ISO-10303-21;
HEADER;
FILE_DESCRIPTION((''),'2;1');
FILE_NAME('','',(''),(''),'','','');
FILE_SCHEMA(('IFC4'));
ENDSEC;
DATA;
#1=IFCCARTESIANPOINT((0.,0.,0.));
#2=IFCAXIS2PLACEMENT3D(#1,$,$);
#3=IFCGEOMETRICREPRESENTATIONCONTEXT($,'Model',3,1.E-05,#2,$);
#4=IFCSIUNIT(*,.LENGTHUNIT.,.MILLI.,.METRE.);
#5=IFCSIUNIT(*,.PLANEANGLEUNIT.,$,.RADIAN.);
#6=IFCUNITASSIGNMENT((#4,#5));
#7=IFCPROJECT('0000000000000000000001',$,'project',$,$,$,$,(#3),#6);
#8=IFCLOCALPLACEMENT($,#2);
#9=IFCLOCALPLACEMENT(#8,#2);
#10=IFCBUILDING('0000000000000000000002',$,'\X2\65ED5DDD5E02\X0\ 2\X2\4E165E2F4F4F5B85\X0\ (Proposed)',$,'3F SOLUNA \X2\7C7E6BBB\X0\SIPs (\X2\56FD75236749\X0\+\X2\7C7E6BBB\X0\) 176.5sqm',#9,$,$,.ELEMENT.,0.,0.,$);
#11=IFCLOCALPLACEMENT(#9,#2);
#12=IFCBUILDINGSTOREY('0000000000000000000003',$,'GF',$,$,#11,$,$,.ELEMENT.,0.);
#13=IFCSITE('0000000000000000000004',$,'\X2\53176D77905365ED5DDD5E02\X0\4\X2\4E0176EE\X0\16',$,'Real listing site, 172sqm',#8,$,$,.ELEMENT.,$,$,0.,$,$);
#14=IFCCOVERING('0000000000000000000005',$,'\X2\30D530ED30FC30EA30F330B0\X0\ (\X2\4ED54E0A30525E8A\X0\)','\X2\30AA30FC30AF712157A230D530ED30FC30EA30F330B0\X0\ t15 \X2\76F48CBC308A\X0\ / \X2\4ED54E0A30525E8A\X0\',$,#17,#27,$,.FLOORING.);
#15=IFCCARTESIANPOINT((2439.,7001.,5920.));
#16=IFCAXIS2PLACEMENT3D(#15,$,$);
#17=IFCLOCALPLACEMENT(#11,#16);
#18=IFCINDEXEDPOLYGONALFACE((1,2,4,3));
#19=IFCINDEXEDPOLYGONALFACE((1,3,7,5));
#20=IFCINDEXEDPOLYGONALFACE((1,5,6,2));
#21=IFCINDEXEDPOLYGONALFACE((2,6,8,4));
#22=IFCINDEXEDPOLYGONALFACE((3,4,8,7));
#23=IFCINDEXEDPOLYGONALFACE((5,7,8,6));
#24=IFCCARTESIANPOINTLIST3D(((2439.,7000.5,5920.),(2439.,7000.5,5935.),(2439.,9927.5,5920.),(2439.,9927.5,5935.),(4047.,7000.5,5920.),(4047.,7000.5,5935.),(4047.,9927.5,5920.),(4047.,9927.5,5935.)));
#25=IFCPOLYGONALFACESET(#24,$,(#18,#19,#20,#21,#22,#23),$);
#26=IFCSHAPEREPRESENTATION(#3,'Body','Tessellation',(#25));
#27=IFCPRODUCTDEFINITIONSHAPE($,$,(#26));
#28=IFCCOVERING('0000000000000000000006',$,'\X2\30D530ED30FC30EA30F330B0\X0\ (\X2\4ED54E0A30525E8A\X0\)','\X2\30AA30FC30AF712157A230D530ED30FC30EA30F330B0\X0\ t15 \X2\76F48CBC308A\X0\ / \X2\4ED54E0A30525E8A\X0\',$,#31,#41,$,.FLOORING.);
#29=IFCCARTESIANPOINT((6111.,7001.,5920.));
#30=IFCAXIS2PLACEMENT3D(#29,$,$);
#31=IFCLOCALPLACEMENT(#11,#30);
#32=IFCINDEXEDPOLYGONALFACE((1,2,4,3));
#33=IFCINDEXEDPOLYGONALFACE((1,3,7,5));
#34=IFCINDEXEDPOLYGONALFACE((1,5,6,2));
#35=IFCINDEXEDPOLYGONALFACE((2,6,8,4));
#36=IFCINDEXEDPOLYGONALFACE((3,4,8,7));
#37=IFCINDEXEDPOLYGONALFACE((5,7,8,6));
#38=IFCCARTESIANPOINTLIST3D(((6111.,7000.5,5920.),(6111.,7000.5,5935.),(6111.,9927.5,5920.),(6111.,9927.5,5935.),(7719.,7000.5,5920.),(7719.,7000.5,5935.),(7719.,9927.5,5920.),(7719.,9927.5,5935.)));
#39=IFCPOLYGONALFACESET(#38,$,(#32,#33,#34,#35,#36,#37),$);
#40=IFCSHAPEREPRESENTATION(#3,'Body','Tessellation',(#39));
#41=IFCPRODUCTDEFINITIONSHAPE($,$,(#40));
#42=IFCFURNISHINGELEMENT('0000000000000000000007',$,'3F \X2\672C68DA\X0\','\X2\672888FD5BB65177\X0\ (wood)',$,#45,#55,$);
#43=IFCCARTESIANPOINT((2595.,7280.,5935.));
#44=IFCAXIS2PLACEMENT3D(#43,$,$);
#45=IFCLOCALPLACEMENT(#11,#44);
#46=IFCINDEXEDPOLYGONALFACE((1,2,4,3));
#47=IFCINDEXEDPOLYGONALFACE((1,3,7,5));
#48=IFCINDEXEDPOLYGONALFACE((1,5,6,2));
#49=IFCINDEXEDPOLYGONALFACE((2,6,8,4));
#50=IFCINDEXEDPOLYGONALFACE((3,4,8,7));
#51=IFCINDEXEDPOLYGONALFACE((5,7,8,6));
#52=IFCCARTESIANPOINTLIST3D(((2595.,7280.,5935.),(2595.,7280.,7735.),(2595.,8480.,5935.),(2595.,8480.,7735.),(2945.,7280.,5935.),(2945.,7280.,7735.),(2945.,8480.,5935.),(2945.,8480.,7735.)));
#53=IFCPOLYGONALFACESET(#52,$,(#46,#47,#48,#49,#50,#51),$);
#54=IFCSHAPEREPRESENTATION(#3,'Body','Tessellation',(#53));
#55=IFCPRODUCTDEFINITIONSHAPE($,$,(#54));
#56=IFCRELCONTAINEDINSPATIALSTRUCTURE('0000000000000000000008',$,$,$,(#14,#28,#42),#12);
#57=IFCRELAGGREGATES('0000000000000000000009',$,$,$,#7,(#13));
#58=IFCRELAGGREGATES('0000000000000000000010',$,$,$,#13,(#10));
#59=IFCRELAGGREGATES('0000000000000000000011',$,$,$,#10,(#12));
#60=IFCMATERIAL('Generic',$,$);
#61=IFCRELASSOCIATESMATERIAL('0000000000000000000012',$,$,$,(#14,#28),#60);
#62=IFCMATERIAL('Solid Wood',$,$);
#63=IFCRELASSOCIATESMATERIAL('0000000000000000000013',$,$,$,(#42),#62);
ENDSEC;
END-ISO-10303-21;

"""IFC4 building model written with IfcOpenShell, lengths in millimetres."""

from ifc_helpers import new_model, si_unit, frame, frame_2d, origin, place, context, project, spatial, rectangle, extrude, material, element, save


model = new_model("IFC4")

# Units and contexts
model_context = context("Model", 3, precision=1e-05, world=origin())
ifc_project = project(units=[si_unit("LENGTHUNIT", "METRE", prefix="MILLI"), si_unit("PLANEANGLEUNIT", "RADIAN")], contexts=[model_context])

# Site, building, storey
site_placement = place(None, origin())
site = spatial("IfcSite", under=ifc_project, at=site_placement, Name="北海道旭川市4丁目16", ObjectType="Real listing site, 172sqm", CompositionType="ELEMENT", RefElevation=0.0)
building_placement = place(site_placement, origin())
building = spatial("IfcBuilding", under=site, at=building_placement, Name="旭川市 2世帯住宅 (Proposed)", ObjectType="3F SOLUNA 籾殻SIPs (国産杉+籾殻) 176.5sqm", CompositionType="ELEMENT", ElevationOfRefHeight=0.0, ElevationOfTerrain=0.0)
storey_placement = place(building_placement, origin())
storey = spatial("IfcBuildingStorey", under=building, at=storey_placement, Name="GF", CompositionType="ELEMENT", Elevation=0.0)

# Shared definitions
ifc_material_1 = material(Name="Solid Wood")

# Shared definitions
ifc_material_2 = material(Name="Generic")

# Coverings
covering_1_placement = place(storey_placement, frame((2439.0, 7001.0, 5920.0)))
element("IfcCovering", 1, at=covering_1_placement, inside=storey, material=ifc_material_2, Name="フローリング (仕上げ床)", Description="オーク無垢フローリング t15 直貼り / 仕上げ床", PredefinedType="FLOORING", context=model_context, shape_type="SweptSolid", body=[
    extrude(rectangle(XDim=1608.0, YDim=2927.0, at=frame_2d((804.0, 1463.0))), frame((2439.0, 7001.0, 5920.0)), (0.0, 0.0, 1.0), 15.0),
])
covering_2_placement = place(storey_placement, frame((6111.0, 7001.0, 5920.0)))
element("IfcCovering", 2, at=covering_2_placement, inside=storey, material=ifc_material_2, Name="フローリング (仕上げ床)", Description="オーク無垢フローリング t15 直貼り / 仕上げ床", PredefinedType="FLOORING", context=model_context, shape_type="SweptSolid", body=[
    extrude(rectangle(XDim=1608.0, YDim=2927.0, at=frame_2d((804.0, 1463.0))), frame((6111.0, 7001.0, 5920.0)), (0.0, 0.0, 1.0), 15.0),
])

# Furnishing element
furnishing_placement = place(storey_placement, frame((2595.0, 7280.0, 5935.0)))
element("IfcFurnishingElement", 3, at=furnishing_placement, inside=storey, material=ifc_material_1, Name="3F 本棚", Description="木製家具 (wood)", context=model_context, shape_type="SweptSolid", body=[
    extrude(rectangle(XDim=350.0, YDim=1200.0, at=frame_2d((175.0, 600.0))), frame((2595.0, 7280.0, 5935.0)), (0.0, 0.0, 1.0), 1800.0),
])

save(model, "model.ifc")
